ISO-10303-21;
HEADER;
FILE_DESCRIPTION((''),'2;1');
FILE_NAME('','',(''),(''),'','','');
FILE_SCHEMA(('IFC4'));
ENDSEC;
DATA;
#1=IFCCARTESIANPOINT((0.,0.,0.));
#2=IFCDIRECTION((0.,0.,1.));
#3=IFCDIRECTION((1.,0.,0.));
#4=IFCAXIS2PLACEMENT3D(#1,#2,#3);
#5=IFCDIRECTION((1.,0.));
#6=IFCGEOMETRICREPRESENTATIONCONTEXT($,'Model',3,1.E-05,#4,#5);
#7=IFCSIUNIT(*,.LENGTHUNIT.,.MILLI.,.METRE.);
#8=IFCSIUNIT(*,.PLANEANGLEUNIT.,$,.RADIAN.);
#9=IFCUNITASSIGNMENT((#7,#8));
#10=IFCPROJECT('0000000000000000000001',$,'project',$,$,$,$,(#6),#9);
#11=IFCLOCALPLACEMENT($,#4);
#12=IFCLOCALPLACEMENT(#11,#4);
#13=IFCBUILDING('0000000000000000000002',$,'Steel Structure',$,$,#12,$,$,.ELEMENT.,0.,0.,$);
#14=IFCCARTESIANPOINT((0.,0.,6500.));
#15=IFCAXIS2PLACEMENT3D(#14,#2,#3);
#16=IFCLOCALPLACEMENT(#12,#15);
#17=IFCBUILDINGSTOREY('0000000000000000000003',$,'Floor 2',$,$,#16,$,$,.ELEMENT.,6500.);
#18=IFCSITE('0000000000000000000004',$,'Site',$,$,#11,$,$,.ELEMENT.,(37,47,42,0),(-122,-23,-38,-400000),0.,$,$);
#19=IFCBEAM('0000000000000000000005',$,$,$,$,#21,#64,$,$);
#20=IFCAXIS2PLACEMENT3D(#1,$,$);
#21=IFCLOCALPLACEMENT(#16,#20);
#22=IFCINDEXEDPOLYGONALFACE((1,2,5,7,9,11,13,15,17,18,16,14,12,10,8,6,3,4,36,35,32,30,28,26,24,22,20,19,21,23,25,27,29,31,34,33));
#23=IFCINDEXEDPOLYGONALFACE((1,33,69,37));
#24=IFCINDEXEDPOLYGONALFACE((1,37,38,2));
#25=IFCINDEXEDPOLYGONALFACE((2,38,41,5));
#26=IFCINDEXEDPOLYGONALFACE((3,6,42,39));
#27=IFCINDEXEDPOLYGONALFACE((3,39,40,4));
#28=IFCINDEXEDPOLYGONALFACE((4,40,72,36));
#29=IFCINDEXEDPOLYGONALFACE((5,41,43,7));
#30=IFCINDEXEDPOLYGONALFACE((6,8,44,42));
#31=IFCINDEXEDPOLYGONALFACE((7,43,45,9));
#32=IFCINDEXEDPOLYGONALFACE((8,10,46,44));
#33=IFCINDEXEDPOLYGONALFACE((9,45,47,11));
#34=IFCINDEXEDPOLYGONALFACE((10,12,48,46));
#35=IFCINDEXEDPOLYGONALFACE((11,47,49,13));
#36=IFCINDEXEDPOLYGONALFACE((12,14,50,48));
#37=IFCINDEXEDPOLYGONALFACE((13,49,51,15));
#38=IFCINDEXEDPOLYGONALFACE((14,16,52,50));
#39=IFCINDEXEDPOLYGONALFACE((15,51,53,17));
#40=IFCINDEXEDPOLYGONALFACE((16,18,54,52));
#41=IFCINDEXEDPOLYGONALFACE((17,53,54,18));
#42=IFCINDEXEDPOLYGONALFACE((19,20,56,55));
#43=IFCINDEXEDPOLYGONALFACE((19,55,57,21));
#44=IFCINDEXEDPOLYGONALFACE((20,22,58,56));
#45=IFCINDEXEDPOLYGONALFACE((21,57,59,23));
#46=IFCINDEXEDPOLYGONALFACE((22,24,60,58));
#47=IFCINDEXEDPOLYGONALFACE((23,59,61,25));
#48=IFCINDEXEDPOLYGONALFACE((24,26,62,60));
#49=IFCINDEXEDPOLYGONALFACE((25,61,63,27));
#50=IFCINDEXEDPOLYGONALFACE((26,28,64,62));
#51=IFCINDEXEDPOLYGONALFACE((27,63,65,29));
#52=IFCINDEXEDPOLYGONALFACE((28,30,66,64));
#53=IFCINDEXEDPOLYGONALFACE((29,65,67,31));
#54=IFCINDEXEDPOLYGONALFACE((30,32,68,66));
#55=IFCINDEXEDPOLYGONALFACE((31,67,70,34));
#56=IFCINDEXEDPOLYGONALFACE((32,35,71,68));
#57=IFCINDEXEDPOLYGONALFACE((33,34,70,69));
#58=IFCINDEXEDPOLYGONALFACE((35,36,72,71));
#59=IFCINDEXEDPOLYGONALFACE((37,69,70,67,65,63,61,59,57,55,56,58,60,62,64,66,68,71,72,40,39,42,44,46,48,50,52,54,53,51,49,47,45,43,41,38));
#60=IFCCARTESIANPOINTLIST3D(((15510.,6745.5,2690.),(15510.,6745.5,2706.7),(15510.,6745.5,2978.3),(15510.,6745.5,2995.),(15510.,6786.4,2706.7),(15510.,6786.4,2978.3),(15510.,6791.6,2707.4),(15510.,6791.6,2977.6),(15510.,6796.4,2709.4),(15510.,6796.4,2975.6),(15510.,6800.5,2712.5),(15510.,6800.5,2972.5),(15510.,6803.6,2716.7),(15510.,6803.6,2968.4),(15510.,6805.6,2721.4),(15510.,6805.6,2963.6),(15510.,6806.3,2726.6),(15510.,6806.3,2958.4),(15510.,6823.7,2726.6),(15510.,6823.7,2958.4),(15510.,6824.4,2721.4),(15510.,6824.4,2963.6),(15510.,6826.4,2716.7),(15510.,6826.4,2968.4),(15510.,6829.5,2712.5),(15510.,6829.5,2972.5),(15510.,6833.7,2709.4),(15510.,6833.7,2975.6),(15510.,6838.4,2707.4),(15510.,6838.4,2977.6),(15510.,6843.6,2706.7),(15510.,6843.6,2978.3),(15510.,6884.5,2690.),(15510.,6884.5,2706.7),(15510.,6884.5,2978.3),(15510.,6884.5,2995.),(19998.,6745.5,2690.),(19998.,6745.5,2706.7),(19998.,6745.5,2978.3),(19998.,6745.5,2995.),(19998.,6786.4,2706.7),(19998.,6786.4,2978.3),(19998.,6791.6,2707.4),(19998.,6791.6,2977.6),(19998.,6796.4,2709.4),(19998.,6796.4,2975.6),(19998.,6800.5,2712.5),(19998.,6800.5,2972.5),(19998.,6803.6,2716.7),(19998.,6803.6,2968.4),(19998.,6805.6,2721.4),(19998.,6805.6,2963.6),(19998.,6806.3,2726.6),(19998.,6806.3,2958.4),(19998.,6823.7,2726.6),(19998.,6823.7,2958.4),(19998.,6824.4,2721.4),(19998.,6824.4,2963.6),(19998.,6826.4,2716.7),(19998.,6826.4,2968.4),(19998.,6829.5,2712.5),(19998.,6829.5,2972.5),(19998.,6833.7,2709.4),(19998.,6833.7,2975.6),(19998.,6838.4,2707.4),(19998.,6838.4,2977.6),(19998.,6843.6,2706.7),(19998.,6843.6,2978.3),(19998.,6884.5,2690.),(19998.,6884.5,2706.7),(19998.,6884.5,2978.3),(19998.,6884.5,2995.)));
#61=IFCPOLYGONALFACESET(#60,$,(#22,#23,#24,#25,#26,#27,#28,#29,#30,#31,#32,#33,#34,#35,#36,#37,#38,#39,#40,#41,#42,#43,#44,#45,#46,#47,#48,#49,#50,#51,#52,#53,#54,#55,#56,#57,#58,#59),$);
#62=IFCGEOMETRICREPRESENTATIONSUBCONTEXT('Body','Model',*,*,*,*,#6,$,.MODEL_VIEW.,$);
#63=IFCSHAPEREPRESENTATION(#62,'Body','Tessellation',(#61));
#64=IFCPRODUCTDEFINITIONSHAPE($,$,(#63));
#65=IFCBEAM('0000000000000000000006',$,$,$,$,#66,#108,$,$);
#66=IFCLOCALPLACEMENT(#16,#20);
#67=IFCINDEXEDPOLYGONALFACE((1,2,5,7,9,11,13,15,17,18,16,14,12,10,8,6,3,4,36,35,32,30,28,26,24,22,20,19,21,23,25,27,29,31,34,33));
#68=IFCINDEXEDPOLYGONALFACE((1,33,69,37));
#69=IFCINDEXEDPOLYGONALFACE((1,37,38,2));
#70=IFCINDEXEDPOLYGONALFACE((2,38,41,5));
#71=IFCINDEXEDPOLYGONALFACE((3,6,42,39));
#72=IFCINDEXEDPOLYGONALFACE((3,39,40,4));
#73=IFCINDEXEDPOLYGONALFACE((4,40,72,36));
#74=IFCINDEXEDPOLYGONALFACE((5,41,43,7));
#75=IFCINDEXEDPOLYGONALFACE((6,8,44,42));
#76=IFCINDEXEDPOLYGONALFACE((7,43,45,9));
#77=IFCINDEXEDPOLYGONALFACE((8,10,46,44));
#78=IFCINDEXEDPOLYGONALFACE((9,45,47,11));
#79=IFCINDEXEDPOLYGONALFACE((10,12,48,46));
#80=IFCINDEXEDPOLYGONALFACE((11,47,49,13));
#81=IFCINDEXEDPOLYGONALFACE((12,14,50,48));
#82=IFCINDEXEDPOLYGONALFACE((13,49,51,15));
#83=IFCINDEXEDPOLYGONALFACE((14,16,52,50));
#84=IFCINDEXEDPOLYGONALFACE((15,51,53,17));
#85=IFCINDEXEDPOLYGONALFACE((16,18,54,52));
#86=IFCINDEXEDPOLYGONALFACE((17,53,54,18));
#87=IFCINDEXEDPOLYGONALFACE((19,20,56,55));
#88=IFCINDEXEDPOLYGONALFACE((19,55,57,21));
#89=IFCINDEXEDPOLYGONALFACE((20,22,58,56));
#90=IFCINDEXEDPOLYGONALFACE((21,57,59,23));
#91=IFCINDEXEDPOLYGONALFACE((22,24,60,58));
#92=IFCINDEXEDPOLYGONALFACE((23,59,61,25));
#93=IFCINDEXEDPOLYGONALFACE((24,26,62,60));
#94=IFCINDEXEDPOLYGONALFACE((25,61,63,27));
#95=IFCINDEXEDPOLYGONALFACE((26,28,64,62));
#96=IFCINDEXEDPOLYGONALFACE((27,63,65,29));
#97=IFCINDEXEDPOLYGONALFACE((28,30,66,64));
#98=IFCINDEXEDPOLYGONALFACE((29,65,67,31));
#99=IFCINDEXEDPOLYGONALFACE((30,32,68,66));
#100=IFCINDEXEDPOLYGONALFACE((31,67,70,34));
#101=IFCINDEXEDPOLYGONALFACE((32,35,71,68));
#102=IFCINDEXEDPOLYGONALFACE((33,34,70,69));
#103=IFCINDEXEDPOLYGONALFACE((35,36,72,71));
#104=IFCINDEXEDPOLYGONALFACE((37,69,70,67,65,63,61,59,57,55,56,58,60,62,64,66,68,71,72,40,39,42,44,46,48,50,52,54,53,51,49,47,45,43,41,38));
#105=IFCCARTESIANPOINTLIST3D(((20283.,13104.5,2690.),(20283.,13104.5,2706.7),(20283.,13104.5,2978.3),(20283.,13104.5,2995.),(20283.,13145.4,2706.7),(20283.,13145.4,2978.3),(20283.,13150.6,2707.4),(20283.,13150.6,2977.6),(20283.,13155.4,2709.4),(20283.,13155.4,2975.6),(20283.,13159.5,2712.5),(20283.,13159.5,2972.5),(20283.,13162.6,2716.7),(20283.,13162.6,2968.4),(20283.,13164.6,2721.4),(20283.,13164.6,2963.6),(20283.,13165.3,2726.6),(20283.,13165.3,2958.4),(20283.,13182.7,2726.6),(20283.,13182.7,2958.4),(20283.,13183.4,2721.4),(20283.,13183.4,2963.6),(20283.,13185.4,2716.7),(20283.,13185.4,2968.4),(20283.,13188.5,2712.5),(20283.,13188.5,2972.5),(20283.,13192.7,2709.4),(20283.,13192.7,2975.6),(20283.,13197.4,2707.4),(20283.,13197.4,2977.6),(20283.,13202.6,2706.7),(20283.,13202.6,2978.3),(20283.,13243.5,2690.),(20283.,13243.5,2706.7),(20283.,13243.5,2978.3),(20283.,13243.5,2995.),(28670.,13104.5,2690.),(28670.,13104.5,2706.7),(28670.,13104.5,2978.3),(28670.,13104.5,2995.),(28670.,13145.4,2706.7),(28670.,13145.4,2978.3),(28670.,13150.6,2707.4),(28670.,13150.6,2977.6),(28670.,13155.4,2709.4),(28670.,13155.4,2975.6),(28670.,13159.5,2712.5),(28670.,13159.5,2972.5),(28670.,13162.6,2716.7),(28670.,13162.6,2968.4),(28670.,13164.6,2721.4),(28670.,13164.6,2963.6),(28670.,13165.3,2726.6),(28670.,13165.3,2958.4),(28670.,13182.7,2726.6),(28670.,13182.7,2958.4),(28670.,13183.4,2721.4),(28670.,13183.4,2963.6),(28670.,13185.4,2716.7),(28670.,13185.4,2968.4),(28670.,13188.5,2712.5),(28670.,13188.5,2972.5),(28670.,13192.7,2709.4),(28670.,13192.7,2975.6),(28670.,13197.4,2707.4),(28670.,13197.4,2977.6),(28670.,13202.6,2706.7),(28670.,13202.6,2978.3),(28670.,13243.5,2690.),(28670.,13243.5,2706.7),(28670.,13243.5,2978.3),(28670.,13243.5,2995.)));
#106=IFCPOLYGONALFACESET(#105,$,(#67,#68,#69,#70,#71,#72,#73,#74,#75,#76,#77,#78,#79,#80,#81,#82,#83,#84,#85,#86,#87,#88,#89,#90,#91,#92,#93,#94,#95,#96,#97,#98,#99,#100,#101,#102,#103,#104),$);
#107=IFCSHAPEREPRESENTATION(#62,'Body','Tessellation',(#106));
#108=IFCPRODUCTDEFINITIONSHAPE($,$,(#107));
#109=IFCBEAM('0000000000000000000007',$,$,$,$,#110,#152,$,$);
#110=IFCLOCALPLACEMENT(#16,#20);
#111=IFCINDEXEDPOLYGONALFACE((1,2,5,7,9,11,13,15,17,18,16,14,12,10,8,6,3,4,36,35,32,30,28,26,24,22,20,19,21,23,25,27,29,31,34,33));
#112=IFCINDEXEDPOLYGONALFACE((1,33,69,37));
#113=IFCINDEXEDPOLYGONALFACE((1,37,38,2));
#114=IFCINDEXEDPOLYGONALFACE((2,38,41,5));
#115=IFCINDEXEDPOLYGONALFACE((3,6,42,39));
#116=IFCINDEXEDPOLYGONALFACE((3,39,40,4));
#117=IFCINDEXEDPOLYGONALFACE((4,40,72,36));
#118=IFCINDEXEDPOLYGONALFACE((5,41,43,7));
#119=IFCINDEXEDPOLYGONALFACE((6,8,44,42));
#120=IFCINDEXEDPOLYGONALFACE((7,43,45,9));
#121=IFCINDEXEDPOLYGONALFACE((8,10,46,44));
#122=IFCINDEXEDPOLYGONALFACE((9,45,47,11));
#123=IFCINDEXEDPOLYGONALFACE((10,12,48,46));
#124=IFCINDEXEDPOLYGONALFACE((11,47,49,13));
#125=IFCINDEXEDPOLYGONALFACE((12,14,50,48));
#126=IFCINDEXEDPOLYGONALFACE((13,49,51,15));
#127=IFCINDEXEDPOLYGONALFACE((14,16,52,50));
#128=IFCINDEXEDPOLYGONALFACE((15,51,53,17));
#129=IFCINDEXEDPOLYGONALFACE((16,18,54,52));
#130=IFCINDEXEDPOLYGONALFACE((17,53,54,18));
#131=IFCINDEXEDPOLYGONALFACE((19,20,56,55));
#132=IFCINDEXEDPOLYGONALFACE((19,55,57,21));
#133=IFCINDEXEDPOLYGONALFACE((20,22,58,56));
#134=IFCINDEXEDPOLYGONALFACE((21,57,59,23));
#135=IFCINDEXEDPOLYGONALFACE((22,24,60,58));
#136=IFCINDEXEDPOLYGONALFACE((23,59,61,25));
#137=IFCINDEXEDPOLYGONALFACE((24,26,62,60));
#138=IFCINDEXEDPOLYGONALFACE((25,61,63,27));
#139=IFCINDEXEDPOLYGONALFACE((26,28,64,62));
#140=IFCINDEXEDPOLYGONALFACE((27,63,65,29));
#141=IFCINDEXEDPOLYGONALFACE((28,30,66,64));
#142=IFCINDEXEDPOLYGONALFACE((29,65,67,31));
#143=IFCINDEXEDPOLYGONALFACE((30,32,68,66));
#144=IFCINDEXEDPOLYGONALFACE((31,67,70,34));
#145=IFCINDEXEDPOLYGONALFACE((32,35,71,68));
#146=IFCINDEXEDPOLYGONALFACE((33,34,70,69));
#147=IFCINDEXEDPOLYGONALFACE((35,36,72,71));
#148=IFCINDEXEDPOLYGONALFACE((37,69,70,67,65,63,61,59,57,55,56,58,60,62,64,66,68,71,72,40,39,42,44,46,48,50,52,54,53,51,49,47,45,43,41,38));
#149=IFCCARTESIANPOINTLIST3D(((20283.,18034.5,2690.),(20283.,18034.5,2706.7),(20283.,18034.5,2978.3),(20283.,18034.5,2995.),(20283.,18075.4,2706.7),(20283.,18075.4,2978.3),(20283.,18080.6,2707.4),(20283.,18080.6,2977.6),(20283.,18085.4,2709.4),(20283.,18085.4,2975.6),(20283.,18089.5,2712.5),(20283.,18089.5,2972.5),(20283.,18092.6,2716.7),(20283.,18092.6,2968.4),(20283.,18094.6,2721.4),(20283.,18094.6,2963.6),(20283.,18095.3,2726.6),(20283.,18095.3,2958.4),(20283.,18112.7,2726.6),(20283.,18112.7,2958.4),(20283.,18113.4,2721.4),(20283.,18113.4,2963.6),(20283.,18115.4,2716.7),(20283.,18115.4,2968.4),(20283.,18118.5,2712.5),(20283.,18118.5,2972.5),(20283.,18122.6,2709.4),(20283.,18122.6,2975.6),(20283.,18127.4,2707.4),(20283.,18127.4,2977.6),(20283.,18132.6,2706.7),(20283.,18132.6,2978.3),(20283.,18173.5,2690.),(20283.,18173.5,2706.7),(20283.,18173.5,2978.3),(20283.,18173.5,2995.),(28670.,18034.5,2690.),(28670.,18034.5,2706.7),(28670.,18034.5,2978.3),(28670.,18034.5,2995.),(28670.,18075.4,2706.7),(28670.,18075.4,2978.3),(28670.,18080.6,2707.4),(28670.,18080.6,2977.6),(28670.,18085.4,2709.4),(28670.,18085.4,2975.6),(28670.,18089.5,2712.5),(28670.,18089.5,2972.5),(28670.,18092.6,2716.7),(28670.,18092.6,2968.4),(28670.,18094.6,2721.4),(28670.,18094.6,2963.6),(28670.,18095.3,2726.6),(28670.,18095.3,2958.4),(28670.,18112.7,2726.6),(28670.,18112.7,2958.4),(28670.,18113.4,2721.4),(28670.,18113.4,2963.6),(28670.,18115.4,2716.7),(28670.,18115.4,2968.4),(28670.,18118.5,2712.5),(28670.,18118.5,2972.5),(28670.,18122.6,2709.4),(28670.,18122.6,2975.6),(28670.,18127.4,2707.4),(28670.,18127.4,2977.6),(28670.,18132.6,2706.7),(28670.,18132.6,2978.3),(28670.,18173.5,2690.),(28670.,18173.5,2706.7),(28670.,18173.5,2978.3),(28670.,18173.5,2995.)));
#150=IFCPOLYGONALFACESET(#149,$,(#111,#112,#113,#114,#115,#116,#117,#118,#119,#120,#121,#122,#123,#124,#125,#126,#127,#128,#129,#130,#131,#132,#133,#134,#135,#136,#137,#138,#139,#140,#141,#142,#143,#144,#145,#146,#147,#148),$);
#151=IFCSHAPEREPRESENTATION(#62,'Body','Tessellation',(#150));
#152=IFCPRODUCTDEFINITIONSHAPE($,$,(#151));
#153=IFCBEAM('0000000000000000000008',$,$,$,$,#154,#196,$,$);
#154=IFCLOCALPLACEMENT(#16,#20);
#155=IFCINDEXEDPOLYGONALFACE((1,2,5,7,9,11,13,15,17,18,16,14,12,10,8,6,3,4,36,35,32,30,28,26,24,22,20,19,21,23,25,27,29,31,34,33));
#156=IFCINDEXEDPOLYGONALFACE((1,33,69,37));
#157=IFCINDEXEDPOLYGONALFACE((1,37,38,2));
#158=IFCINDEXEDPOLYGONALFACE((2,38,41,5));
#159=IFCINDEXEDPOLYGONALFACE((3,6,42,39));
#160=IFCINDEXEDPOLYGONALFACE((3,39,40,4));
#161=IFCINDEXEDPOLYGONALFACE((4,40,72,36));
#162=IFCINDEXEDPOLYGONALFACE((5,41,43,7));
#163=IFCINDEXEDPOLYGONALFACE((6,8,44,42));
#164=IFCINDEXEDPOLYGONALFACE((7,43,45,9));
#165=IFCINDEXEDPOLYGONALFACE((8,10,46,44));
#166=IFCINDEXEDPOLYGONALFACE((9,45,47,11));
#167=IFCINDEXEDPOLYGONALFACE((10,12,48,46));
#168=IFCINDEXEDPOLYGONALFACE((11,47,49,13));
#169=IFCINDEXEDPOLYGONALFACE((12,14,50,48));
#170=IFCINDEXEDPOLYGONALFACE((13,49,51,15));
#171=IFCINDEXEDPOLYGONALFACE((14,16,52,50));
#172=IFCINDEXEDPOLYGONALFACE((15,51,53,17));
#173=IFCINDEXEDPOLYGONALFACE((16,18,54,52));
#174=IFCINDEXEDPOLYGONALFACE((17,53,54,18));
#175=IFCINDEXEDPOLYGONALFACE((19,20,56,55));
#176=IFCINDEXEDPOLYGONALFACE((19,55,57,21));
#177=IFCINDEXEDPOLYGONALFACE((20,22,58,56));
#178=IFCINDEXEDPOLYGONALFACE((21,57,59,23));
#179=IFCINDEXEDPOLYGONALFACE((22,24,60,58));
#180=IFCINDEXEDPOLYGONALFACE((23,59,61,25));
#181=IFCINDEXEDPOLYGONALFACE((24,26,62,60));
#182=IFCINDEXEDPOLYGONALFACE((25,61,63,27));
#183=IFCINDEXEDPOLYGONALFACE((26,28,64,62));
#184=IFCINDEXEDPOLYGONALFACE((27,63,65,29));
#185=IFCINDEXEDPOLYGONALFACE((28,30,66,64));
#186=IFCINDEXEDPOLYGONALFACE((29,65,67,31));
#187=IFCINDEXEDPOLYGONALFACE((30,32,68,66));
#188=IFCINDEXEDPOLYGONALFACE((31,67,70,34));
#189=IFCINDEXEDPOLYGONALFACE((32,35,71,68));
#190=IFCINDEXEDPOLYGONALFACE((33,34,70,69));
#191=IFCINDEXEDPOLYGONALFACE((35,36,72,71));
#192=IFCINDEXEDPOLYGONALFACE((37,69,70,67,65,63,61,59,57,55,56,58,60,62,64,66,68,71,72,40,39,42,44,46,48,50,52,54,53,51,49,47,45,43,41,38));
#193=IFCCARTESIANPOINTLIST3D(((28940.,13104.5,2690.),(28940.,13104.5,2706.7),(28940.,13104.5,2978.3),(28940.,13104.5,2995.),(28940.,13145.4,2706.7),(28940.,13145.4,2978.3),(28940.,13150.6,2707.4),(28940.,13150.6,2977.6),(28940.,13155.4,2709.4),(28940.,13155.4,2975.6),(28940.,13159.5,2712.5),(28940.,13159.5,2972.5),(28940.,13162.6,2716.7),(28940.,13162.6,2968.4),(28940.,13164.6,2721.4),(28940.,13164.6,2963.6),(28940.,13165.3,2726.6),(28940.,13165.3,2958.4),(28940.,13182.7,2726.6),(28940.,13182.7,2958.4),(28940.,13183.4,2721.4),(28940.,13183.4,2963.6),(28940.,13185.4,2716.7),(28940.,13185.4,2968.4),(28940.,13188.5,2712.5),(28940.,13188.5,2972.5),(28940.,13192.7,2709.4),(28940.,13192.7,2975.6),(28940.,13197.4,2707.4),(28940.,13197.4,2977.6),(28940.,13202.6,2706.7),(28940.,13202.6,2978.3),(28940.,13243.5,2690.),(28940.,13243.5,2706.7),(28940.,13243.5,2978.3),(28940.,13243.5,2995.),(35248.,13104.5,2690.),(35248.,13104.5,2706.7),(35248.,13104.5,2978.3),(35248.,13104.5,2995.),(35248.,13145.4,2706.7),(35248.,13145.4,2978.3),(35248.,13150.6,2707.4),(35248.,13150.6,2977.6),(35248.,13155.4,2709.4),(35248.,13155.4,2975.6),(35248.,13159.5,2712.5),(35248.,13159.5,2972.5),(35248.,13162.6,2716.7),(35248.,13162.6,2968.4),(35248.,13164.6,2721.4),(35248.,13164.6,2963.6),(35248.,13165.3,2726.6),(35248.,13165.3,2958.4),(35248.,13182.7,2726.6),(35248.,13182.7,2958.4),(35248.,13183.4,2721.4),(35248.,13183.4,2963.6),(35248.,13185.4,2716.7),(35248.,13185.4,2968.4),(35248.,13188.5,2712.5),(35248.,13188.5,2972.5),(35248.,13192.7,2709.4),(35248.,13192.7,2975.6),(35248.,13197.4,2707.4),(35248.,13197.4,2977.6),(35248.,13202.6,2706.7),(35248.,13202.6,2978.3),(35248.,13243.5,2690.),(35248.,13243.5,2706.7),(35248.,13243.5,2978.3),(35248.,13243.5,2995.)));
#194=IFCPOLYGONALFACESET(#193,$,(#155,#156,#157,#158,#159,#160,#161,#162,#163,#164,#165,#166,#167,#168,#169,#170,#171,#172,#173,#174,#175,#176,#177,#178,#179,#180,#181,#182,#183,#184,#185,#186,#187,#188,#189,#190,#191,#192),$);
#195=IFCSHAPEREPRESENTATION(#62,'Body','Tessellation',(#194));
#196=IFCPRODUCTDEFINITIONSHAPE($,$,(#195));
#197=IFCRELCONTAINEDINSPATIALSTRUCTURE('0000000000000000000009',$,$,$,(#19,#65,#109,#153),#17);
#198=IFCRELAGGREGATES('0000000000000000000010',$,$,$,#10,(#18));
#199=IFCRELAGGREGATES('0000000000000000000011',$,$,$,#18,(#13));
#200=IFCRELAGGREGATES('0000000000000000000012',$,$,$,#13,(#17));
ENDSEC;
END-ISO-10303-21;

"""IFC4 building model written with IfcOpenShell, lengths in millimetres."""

from ifc_helpers import new_model, si_unit, direction, frame, origin_with_axes, origin_2d_with_axis, place, context, subcontext, project, spatial, i_section, extrude, element, save


model = new_model("IFC4")

# Units and contexts
model_context = context("Model", 3, precision=1e-05, world=origin_with_axes(), true_north=direction((1.0, 0.0)))
body_context = subcontext(model_context, "Body", "Model", "MODEL_VIEW")
ifc_project = project(units=[si_unit("LENGTHUNIT", "METRE", prefix="MILLI"), si_unit("PLANEANGLEUNIT", "RADIAN")], contexts=[model_context])

# Site, building, storey
site_placement = place(None, origin_with_axes())
site = spatial("IfcSite", under=ifc_project, at=site_placement, Name="Site", CompositionType="ELEMENT", RefLatitude=(37, 47, 42, 0), RefLongitude=(-122, -23, -38, -400000), RefElevation=0.0)
building_placement = place(site_placement, origin_with_axes())
building = spatial("IfcBuilding", under=site, at=building_placement, Name="Steel Structure", CompositionType="ELEMENT", ElevationOfRefHeight=0.0, ElevationOfTerrain=0.0)
storey_placement = place(building_placement, frame((0.0, 0.0, 6500.0), z_axis=(0.0, 0.0, 1.0), x_axis=(1.0, 0.0, 0.0)))
storey = spatial("IfcBuildingStorey", under=building, at=storey_placement, Name="Floor 2", CompositionType="ELEMENT", Elevation=6500.0)

# Beams
for number, where, z_axis, x_axis in (
    (1, (19998.0, 6815.0, 2690.0), (-1.0, 0.0, 0.0), (0.0, -1.0, 0.0)),
):
    element("IfcBeam", number, at=place(storey_placement, frame(where, z_axis=z_axis, x_axis=x_axis)), inside=storey, context=body_context, shape_type="SweptSolid", body=[
        extrude(i_section(OverallWidth=139.0, OverallDepth=305.0, WebThickness=17.4, FlangeThickness=16.7, FilletRadius=19.9, at=origin_2d_with_axis()), frame((0.0, 152.5, 0.0), z_axis=(0.0, 0.0, 1.0), x_axis=(1.0, 0.0, 0.0)), (0.0, 0.0, 1.0), 4488.0),
    ])
for number, where, z_axis, x_axis in (
    (2, (20283.0, 13174.0, 2690.0), (1.0, 0.0, 0.0), (0.0, 1.0, 0.0)),
    (3, (28670.0, 18104.0, 2690.0), (-1.0, 0.0, 0.0), (0.0, -1.0, 0.0)),
):
    element("IfcBeam", number, at=place(storey_placement, frame(where, z_axis=z_axis, x_axis=x_axis)), inside=storey, context=body_context, shape_type="SweptSolid", body=[
        extrude(i_section(OverallWidth=139.0, OverallDepth=305.0, WebThickness=17.4, FlangeThickness=16.7, FilletRadius=19.9, at=origin_2d_with_axis()), frame((0.0, 152.5, 0.0), z_axis=(0.0, 0.0, 1.0), x_axis=(1.0, 0.0, 0.0)), (0.0, 0.0, 1.0), 8387.0),
    ])
for number, where, z_axis, x_axis in (
    (4, (28940.0, 13174.0, 2690.0), (1.0, 0.0, 0.0), (0.0, 1.0, 0.0)),
):
    element("IfcBeam", number, at=place(storey_placement, frame(where, z_axis=z_axis, x_axis=x_axis)), inside=storey, context=body_context, shape_type="SweptSolid", body=[
        extrude(i_section(OverallWidth=139.0, OverallDepth=305.0, WebThickness=17.4, FlangeThickness=16.7, FilletRadius=19.9, at=origin_2d_with_axis()), frame((0.0, 152.5, 0.0), z_axis=(0.0, 0.0, 1.0), x_axis=(1.0, 0.0, 0.0)), (0.0, 0.0, 1.0), 6308.0),
    ])

save(model, "model.ifc")
